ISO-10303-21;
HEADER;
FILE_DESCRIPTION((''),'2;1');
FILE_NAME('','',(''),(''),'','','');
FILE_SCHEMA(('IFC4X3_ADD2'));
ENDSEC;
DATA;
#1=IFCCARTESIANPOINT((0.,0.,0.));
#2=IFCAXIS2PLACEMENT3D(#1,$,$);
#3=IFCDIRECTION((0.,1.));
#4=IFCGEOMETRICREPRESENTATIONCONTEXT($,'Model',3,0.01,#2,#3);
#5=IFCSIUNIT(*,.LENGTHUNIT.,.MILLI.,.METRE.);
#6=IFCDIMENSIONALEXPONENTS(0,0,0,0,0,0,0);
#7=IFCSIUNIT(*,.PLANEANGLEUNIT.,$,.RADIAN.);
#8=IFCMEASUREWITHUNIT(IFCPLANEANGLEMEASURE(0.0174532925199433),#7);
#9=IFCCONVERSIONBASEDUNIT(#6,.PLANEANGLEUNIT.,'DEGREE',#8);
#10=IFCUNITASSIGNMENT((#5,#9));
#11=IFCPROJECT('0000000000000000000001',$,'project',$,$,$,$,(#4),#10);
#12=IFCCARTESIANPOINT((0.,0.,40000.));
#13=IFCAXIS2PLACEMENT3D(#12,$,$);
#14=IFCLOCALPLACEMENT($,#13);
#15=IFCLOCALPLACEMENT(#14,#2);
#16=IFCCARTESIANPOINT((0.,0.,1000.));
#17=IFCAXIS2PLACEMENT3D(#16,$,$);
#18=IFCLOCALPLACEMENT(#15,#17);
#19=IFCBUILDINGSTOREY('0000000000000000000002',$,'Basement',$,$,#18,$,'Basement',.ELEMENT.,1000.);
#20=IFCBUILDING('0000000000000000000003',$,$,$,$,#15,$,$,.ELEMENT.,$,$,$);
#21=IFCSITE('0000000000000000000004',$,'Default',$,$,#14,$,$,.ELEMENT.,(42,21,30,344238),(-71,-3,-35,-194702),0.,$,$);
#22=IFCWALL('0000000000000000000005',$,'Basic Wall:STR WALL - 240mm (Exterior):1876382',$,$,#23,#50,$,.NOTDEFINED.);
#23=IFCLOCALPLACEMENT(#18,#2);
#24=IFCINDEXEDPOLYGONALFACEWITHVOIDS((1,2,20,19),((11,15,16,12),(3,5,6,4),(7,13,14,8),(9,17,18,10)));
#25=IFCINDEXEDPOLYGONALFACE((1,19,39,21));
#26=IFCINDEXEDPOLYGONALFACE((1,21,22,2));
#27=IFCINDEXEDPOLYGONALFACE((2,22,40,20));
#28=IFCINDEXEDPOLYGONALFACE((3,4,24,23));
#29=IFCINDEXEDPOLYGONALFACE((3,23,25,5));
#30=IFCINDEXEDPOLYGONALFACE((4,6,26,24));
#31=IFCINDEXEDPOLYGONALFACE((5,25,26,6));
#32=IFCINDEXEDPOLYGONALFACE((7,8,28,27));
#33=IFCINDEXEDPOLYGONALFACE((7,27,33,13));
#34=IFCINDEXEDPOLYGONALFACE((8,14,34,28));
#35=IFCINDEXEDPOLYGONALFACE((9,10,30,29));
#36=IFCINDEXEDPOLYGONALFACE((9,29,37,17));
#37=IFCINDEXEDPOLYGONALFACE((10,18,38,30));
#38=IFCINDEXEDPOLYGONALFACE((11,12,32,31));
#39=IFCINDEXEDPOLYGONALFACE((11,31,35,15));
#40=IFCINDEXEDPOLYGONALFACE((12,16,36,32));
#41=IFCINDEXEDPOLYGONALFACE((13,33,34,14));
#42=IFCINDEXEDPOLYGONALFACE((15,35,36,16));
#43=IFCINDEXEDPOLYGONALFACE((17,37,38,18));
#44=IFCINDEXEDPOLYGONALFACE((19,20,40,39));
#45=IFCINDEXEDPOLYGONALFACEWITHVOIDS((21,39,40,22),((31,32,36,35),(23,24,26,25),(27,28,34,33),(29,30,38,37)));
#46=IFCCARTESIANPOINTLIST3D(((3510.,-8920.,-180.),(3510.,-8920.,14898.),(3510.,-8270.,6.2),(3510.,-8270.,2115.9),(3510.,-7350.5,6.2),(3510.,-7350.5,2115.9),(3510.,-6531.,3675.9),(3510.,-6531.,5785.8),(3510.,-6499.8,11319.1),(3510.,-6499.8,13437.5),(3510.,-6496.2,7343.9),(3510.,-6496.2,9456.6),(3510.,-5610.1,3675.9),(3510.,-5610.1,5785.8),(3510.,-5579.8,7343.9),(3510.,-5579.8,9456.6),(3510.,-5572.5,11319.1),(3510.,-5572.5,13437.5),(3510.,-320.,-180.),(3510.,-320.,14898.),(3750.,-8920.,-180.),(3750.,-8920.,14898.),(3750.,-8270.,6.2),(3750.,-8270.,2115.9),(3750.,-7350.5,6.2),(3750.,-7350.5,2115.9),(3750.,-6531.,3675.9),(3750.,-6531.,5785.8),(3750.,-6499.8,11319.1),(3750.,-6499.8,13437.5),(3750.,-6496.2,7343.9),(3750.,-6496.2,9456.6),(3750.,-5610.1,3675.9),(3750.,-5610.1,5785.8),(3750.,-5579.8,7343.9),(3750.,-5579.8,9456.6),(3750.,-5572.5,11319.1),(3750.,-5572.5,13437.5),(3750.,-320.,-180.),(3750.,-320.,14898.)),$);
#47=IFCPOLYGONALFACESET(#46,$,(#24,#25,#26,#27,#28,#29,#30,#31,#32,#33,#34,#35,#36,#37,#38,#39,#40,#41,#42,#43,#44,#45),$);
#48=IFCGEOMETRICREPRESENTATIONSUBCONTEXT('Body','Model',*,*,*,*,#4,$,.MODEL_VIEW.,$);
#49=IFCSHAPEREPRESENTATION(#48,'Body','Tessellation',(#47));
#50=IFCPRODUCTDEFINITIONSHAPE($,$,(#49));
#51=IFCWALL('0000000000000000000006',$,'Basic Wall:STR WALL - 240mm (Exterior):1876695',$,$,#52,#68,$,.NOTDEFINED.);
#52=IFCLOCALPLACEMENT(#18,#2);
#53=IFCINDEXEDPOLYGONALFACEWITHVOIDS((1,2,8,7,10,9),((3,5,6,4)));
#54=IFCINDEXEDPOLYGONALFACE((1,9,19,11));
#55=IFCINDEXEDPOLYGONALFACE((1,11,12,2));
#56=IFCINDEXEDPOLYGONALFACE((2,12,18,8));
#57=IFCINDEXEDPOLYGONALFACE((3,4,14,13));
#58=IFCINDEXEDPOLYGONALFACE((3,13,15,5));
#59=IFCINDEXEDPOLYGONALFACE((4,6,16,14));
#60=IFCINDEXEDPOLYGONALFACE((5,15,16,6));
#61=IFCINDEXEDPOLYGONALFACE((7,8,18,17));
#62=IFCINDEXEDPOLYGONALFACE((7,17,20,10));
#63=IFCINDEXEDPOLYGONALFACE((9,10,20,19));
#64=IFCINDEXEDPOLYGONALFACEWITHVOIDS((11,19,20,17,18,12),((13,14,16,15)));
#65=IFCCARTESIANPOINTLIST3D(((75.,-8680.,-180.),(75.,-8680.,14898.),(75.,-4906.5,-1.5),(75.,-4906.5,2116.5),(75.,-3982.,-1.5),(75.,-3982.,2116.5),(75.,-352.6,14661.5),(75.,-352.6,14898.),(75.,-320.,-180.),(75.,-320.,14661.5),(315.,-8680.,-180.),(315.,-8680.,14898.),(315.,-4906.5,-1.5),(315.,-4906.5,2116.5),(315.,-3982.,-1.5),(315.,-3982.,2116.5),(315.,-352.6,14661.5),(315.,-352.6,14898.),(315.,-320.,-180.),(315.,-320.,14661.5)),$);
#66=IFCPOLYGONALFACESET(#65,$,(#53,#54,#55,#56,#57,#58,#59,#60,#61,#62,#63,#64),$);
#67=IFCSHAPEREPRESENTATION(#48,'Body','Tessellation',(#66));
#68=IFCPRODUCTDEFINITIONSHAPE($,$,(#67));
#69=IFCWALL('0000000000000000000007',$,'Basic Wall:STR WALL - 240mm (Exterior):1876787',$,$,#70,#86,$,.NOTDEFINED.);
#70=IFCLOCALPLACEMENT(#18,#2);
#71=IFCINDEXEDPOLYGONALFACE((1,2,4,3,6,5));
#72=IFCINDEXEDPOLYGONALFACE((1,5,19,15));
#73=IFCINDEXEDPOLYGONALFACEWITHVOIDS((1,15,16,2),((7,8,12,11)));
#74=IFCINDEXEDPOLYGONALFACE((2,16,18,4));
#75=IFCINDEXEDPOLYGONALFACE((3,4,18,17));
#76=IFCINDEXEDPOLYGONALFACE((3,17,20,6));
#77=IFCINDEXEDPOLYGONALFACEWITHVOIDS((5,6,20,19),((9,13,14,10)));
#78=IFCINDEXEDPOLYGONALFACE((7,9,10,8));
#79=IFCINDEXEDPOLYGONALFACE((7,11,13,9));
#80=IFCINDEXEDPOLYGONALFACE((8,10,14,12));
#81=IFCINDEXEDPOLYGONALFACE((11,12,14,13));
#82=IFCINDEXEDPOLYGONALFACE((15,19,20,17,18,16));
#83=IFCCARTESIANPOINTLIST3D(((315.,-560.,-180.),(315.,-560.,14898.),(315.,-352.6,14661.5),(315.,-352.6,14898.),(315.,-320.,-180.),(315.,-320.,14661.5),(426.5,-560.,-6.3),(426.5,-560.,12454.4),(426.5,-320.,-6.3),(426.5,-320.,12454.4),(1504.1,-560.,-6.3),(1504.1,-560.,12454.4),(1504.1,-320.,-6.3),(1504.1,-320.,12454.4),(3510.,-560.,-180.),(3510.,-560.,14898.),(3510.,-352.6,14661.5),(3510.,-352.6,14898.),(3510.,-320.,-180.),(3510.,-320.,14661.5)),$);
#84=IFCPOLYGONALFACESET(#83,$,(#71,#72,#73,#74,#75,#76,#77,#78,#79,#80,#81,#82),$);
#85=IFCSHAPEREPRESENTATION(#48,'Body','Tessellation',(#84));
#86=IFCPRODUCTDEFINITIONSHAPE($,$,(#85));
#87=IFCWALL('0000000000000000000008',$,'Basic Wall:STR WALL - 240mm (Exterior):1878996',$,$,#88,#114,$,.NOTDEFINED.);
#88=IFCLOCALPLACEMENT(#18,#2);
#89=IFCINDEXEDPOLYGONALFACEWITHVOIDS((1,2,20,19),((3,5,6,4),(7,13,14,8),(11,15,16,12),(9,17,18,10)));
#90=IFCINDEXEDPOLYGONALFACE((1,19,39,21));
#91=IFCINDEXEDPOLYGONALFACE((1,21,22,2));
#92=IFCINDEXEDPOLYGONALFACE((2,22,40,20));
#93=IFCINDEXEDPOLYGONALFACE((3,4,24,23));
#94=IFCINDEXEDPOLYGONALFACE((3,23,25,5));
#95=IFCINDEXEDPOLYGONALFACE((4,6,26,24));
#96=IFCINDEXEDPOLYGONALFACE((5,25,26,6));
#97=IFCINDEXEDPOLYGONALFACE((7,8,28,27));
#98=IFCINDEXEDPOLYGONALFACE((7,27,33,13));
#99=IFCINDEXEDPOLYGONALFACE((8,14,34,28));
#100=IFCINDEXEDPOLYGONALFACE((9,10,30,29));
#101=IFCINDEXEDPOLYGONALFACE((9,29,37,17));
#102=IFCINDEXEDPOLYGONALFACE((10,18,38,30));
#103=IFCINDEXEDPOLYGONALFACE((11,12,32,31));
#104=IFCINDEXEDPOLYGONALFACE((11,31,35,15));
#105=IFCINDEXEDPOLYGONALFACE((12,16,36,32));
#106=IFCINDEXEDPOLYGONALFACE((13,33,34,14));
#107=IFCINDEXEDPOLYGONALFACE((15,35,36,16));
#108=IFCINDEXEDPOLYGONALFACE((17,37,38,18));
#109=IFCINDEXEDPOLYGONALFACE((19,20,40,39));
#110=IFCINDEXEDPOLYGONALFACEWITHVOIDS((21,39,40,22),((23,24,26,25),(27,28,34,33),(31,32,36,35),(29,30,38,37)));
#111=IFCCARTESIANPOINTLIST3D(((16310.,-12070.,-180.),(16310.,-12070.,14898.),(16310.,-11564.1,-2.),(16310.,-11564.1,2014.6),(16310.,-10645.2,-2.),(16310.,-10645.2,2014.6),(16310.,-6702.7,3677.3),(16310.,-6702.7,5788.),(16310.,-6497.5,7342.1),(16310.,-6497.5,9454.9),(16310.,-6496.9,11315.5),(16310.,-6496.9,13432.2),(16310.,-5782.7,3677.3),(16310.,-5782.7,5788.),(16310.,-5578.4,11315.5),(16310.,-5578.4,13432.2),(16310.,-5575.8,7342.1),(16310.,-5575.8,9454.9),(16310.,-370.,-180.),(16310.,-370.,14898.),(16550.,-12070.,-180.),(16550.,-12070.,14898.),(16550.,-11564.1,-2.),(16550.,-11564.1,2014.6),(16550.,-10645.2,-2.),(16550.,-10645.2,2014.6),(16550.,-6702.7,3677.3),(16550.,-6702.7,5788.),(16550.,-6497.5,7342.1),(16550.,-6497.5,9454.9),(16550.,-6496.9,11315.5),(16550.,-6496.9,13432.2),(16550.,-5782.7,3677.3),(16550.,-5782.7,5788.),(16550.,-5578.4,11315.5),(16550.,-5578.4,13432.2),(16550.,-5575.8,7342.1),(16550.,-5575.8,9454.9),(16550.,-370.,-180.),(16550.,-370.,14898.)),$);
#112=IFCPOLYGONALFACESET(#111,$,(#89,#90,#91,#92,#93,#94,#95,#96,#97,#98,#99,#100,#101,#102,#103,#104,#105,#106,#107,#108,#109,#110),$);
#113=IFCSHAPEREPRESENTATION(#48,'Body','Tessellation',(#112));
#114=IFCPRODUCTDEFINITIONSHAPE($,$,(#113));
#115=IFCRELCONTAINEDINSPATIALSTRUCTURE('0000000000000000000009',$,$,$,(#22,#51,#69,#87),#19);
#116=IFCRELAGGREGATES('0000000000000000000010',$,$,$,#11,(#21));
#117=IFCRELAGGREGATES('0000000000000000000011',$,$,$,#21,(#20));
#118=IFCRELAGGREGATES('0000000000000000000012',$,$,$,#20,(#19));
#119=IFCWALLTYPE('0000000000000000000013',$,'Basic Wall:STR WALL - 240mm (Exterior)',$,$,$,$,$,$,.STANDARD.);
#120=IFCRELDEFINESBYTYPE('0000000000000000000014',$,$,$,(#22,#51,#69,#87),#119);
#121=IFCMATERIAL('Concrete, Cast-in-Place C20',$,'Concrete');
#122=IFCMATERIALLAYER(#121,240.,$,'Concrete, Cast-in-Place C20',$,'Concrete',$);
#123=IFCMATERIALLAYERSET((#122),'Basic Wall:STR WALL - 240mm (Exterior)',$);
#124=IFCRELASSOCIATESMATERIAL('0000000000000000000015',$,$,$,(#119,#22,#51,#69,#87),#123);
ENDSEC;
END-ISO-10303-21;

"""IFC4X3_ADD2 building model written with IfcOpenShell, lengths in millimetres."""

from ifc_helpers import new_model, entity, si_unit, converted_unit, direction, frame, frame_2d, origin, origin_2d_with_axis, place, context, subcontext, project, spatial, polyline, rectangle, extrude, clip, bounded_halfspace, material, layer, layer_set, type_object, element, save


model = new_model("IFC4X3_ADD2")

# Units and contexts
model_context = context("Model", 3, precision=0.01, world=origin(), true_north=direction((0.0, 1.0)))
body_context = subcontext(model_context, "Body", "Model", "MODEL_VIEW")
ifc_project = project(units=[si_unit("LENGTHUNIT", "METRE", prefix="MILLI"), converted_unit("PLANEANGLEUNIT", "DEGREE", entity("IfcPlaneAngleMeasure", 0.0174532925199433), si_unit("PLANEANGLEUNIT", "RADIAN"), dimensions=[0, 0, 0, 0, 0, 0, 0])], contexts=[model_context])

# Site, building, storey
site_placement = place(None, frame((0.0, 0.0, 40000.0)))
site = spatial("IfcSite", under=ifc_project, at=site_placement, Name="Default", CompositionType="ELEMENT", RefLatitude=(42, 21, 30, 344238), RefLongitude=(-71, -3, -35, -194702), RefElevation=0.0)
building_placement = place(site_placement, origin())
building = spatial("IfcBuilding", under=site, at=building_placement, CompositionType="ELEMENT")
storey_placement = place(building_placement, frame((0.0, 0.0, 1000.0)))
storey = spatial("IfcBuildingStorey", under=building, at=storey_placement, Name="Basement", LongName="Basement", CompositionType="ELEMENT", Elevation=1000.0)

# Wall, openings
ifc_material_1 = material(Name="Concrete, Cast-in-Place C20", Category="Concrete")
ifc_layer = layer(ifc_material_1, 240.0, Name="Concrete, Cast-in-Place C20", Category="Concrete")
ifc_layer_set = layer_set([ifc_layer], Name="Basic Wall:STR WALL - 240mm (Exterior)")
wall_type = type_object("IfcWallType", Name="Basic Wall:STR WALL - 240mm (Exterior)", PredefinedType="STANDARD", material=ifc_layer_set)
wall_1_placement = place(storey_placement, frame((3630.0, -320.0, -180.0), z_axis=(0.0, 0.0, 1.0), x_axis=(0.0, -1.0, 0.0)))
wall_1 = element("IfcWall", 1, at=wall_1_placement, inside=storey, type_object=wall_type, material=ifc_layer_set, Name="Basic Wall:STR WALL - 240mm (Exterior):1876382", PredefinedType="NOTDEFINED", context=body_context, shape_type="SweptSolid", body=[
    extrude(rectangle(XDim=8600.0, YDim=240.0, at=frame_2d((4300.0, 0.0), x_axis=(-1.0, 0.0))), origin(), (0.0, 0.0, 1.0), 15078.0),
])
opening_1_placement = place(wall_1_placement, frame((6179.8, -120.0, 11499.1)))
element("IfcOpeningElement", 2, at=opening_1_placement, cuts=wall_1, PredefinedType="OPENING", context=body_context, shape_type="SweptSolid", body=[
    extrude(rectangle(XDim=2118.5, YDim=927.3, at=frame_2d((0.0, 0.0), x_axis=(1.0, 0.0))), frame((-463.7, 0.0, 1059.2), z_axis=(0.0, 1.0, 0.0), x_axis=(0.0, 0.0, -1.0)), (0.0, 0.0, 1.0), 240.0),
])
opening_2_placement = place(wall_1_placement, frame((6176.2, -120.0, 7523.9)))
element("IfcOpeningElement", 3, at=opening_2_placement, cuts=wall_1, PredefinedType="OPENING", context=body_context, shape_type="SweptSolid", body=[
    extrude(rectangle(XDim=2112.6, YDim=916.4, at=origin_2d_with_axis()), frame((-458.2, 0.0, 1056.3), z_axis=(0.0, 1.0, 0.0), x_axis=(0.0, 0.0, -1.0)), (0.0, 0.0, 1.0), 240.0),
])
opening_3_placement = place(wall_1_placement, frame((6211.0, -120.0, 3855.9)))
element("IfcOpeningElement", 4, at=opening_3_placement, cuts=wall_1, PredefinedType="OPENING", context=body_context, shape_type="SweptSolid", body=[
    extrude(rectangle(XDim=2109.8, YDim=920.9, at=frame_2d((0.0, 0.0), x_axis=(1.0, 0.0))), frame((-460.4, 0.0, 1054.9), z_axis=(0.0, 1.0, 0.0), x_axis=(0.0, 0.0, -1.0)), (0.0, 0.0, 1.0), 240.0),
])
opening_4_placement = place(wall_1_placement, frame((7950.0, -120.0, 186.2)))
element("IfcOpeningElement", 5, at=opening_4_placement, cuts=wall_1, PredefinedType="OPENING", context=body_context, shape_type="SweptSolid", body=[
    extrude(rectangle(XDim=2109.7, YDim=919.5, at=frame_2d((0.0, 0.0), x_axis=(1.0, 0.0))), frame((-459.8, 0.0, 1054.8), z_axis=(0.0, 1.0, 0.0), x_axis=(0.0, 0.0, -1.0)), (0.0, 0.0, 1.0), 240.0),
])

# Walls, openings
wall_2_placement = place(storey_placement, frame((195.0, -8680.0, -180.0), z_axis=(0.0, 0.0, 1.0), x_axis=(0.0, 1.0, 0.0)))
wall_2 = element("IfcWall", 6, at=wall_2_placement, inside=storey, type_object=wall_type, material=ifc_layer_set, Name="Basic Wall:STR WALL - 240mm (Exterior):1876695", PredefinedType="NOTDEFINED", context=body_context, shape_type="Clipping", body=[
    clip(clip(extrude(rectangle(XDim=8360.0, YDim=240.0, at=frame_2d((4180.0, 0.0), x_axis=(-1.0, 0.0))), origin(), (0.0, 0.0, 1.0), 15078.0), bounded_halfspace(frame((0.0, -120.0, 15078.0), z_axis=(0.0, 0.0, -1.0), x_axis=(0.0, -1.0, 0.0)), True, frame((0.0, -120.0, 15078.0)), polyline([(0.0, 0.0), (8120.0, 0.0), (8327.4, 0.0), (8327.4, 240.0), (0.0, 240.0), (0.0, 0.0)]))), bounded_halfspace(frame((8327.4, -120.0, 14841.5), z_axis=(0.0, 0.0, 1.0), x_axis=(0.0, 1.0, 0.0)), False, frame((8327.4, -120.0, 14841.5)), polyline([(0.0, 0.0), (32.6, 0.0), (32.6, 240.0), (0.0, 240.0), (0.0, 0.0)]))),
])
opening_5_placement = place(wall_2_placement, frame((3773.5, 120.0, 178.5)))
element("IfcOpeningElement", 7, at=opening_5_placement, cuts=wall_2, PredefinedType="OPENING", context=body_context, shape_type="SweptSolid", body=[
    extrude(rectangle(XDim=2118.0, YDim=924.5, at=frame_2d((0.0, 0.0), x_axis=(1.0, 0.0))), frame((462.3, -240.0, 1059.0), z_axis=(0.0, 1.0, 0.0), x_axis=(0.0, 0.0, -1.0)), (0.0, 0.0, 1.0), 240.0),
])
wall_3_placement = place(storey_placement, frame((315.0, -440.0, -180.0)))
wall_3 = element("IfcWall", 8, at=wall_3_placement, inside=storey, type_object=wall_type, material=ifc_layer_set, Name="Basic Wall:STR WALL - 240mm (Exterior):1876787", PredefinedType="NOTDEFINED", context=body_context, shape_type="Clipping", body=[
    clip(clip(extrude(rectangle(XDim=3195.0, YDim=240.0, at=frame_2d((1597.5, 0.0), x_axis=(-1.0, 0.0))), origin(), (0.0, 0.0, 1.0), 15078.0), bounded_halfspace(frame((0.0, -120.0, 15078.0), z_axis=(0.0, 0.0, -1.0), x_axis=(1.0, 0.0, 0.0)), True, frame((0.0, -120.0, 15078.0)), polyline([(0.0, 0.0), (3195.0, 0.0), (3195.0, 207.4), (0.0, 207.4), (0.0, 0.0)]))), bounded_halfspace(frame((3195.0, 87.4, 14841.5), z_axis=(0.0, 0.0, 1.0), x_axis=(0.0, 1.0, 0.0)), False, frame((3195.0, 87.4, 14841.5)), polyline([(0.0, 0.0), (0.0, 32.6), (-3195.0, 32.6), (-3195.0, 0.0), (0.0, 0.0)]))),
])
opening_6_placement = place(wall_3_placement, frame((111.5, -120.0, 173.7)))
element("IfcOpeningElement", 9, at=opening_6_placement, cuts=wall_3, PredefinedType="OPENING", context=body_context, shape_type="SweptSolid", body=[
    extrude(rectangle(XDim=12460.7, YDim=1077.6, at=frame_2d((0.0, 0.0), x_axis=(1.0, 0.0))), frame((538.8, 0.0, 6230.3), z_axis=(0.0, 1.0, 0.0), x_axis=(0.0, 0.0, -1.0)), (0.0, 0.0, 1.0), 240.0),
])

# Wall, openings
wall_4_placement = place(storey_placement, frame((16430.0, -370.0, -180.0), z_axis=(0.0, 0.0, 1.0), x_axis=(0.0, -1.0, 0.0)))
wall_4 = element("IfcWall", 10, at=wall_4_placement, inside=storey, type_object=wall_type, material=ifc_layer_set, Name="Basic Wall:STR WALL - 240mm (Exterior):1878996", PredefinedType="NOTDEFINED", context=body_context, shape_type="Clipping", body=[
    clip(clip(extrude(rectangle(XDim=11700.0, YDim=240.0, at=frame_2d((5850.0, 0.0), x_axis=(-1.0, 0.0))), origin(), (0.0, 0.0, 1.0), 15078.0), bounded_halfspace(frame((0.0, -120.0, 15078.0), z_axis=(0.0, 0.0, -1.0), x_axis=(0.0, 1.0, 0.0)), True, frame((0.0, -120.0, 15078.0)), polyline([(0.0, 0.0), (11700.0, 0.0), (11700.0, 116.7), (0.0, 116.7), (0.0, 0.0)]))), bounded_halfspace(frame((11700.0, -3.3, 15078.0), z_axis=(0.0, 0.0, -1.0), x_axis=(1.0, 0.0, 0.0)), True, frame((11700.0, -3.3, 15078.0)), polyline([(0.0, 0.0), (0.0, 123.3), (-11700.0, 123.3), (-11700.0, 0.0), (0.0, 0.0)]))),
])
opening_7_placement = place(wall_4_placement, frame((11194.1, -120.0, 178.0)))
element("IfcOpeningElement", 11, at=opening_7_placement, cuts=wall_4, PredefinedType="OPENING", context=body_context, shape_type="SweptSolid", body=[
    extrude(rectangle(XDim=2016.6, YDim=918.9, at=frame_2d((0.0, 0.0), x_axis=(1.0, 0.0))), frame((-459.5, 0.0, 1008.3), z_axis=(0.0, 1.0, 0.0), x_axis=(0.0, 0.0, -1.0)), (0.0, 0.0, 1.0), 240.0),
])
opening_8_placement = place(wall_4_placement, frame((6332.7, -120.0, 3857.3)))
element("IfcOpeningElement", 12, at=opening_8_placement, cuts=wall_4, PredefinedType="OPENING", context=body_context, shape_type="SweptSolid", body=[
    extrude(rectangle(XDim=2110.6, YDim=920.0, at=frame_2d((0.0, 0.0), x_axis=(1.0, 0.0))), frame((-460.0, 0.0, 1055.3), z_axis=(0.0, 1.0, 0.0), x_axis=(0.0, 0.0, -1.0)), (0.0, 0.0, 1.0), 240.0),
])
opening_9_placement = place(wall_4_placement, frame((6126.9, -120.0, 11495.5)))
element("IfcOpeningElement", 13, at=opening_9_placement, cuts=wall_4, PredefinedType="OPENING", context=body_context, shape_type="SweptSolid", body=[
    extrude(rectangle(XDim=2116.6, YDim=918.4, at=frame_2d((0.0, 0.0), x_axis=(1.0, 0.0))), frame((-459.2, 0.0, 1058.3), z_axis=(0.0, 1.0, 0.0), x_axis=(0.0, 0.0, -1.0)), (0.0, 0.0, 1.0), 240.0),
])
opening_10_placement = place(wall_4_placement, frame((6127.5, -120.0, 7522.1)))
element("IfcOpeningElement", 14, at=opening_10_placement, cuts=wall_4, PredefinedType="OPENING", context=body_context, shape_type="SweptSolid", body=[
    extrude(rectangle(XDim=2112.7, YDim=921.7, at=frame_2d((0.0, 0.0), x_axis=(1.0, 0.0))), frame((-460.8, 0.0, 1056.4), z_axis=(0.0, 1.0, 0.0), x_axis=(0.0, 0.0, -1.0)), (0.0, 0.0, 1.0), 240.0),
])

save(model, "model.ifc")
